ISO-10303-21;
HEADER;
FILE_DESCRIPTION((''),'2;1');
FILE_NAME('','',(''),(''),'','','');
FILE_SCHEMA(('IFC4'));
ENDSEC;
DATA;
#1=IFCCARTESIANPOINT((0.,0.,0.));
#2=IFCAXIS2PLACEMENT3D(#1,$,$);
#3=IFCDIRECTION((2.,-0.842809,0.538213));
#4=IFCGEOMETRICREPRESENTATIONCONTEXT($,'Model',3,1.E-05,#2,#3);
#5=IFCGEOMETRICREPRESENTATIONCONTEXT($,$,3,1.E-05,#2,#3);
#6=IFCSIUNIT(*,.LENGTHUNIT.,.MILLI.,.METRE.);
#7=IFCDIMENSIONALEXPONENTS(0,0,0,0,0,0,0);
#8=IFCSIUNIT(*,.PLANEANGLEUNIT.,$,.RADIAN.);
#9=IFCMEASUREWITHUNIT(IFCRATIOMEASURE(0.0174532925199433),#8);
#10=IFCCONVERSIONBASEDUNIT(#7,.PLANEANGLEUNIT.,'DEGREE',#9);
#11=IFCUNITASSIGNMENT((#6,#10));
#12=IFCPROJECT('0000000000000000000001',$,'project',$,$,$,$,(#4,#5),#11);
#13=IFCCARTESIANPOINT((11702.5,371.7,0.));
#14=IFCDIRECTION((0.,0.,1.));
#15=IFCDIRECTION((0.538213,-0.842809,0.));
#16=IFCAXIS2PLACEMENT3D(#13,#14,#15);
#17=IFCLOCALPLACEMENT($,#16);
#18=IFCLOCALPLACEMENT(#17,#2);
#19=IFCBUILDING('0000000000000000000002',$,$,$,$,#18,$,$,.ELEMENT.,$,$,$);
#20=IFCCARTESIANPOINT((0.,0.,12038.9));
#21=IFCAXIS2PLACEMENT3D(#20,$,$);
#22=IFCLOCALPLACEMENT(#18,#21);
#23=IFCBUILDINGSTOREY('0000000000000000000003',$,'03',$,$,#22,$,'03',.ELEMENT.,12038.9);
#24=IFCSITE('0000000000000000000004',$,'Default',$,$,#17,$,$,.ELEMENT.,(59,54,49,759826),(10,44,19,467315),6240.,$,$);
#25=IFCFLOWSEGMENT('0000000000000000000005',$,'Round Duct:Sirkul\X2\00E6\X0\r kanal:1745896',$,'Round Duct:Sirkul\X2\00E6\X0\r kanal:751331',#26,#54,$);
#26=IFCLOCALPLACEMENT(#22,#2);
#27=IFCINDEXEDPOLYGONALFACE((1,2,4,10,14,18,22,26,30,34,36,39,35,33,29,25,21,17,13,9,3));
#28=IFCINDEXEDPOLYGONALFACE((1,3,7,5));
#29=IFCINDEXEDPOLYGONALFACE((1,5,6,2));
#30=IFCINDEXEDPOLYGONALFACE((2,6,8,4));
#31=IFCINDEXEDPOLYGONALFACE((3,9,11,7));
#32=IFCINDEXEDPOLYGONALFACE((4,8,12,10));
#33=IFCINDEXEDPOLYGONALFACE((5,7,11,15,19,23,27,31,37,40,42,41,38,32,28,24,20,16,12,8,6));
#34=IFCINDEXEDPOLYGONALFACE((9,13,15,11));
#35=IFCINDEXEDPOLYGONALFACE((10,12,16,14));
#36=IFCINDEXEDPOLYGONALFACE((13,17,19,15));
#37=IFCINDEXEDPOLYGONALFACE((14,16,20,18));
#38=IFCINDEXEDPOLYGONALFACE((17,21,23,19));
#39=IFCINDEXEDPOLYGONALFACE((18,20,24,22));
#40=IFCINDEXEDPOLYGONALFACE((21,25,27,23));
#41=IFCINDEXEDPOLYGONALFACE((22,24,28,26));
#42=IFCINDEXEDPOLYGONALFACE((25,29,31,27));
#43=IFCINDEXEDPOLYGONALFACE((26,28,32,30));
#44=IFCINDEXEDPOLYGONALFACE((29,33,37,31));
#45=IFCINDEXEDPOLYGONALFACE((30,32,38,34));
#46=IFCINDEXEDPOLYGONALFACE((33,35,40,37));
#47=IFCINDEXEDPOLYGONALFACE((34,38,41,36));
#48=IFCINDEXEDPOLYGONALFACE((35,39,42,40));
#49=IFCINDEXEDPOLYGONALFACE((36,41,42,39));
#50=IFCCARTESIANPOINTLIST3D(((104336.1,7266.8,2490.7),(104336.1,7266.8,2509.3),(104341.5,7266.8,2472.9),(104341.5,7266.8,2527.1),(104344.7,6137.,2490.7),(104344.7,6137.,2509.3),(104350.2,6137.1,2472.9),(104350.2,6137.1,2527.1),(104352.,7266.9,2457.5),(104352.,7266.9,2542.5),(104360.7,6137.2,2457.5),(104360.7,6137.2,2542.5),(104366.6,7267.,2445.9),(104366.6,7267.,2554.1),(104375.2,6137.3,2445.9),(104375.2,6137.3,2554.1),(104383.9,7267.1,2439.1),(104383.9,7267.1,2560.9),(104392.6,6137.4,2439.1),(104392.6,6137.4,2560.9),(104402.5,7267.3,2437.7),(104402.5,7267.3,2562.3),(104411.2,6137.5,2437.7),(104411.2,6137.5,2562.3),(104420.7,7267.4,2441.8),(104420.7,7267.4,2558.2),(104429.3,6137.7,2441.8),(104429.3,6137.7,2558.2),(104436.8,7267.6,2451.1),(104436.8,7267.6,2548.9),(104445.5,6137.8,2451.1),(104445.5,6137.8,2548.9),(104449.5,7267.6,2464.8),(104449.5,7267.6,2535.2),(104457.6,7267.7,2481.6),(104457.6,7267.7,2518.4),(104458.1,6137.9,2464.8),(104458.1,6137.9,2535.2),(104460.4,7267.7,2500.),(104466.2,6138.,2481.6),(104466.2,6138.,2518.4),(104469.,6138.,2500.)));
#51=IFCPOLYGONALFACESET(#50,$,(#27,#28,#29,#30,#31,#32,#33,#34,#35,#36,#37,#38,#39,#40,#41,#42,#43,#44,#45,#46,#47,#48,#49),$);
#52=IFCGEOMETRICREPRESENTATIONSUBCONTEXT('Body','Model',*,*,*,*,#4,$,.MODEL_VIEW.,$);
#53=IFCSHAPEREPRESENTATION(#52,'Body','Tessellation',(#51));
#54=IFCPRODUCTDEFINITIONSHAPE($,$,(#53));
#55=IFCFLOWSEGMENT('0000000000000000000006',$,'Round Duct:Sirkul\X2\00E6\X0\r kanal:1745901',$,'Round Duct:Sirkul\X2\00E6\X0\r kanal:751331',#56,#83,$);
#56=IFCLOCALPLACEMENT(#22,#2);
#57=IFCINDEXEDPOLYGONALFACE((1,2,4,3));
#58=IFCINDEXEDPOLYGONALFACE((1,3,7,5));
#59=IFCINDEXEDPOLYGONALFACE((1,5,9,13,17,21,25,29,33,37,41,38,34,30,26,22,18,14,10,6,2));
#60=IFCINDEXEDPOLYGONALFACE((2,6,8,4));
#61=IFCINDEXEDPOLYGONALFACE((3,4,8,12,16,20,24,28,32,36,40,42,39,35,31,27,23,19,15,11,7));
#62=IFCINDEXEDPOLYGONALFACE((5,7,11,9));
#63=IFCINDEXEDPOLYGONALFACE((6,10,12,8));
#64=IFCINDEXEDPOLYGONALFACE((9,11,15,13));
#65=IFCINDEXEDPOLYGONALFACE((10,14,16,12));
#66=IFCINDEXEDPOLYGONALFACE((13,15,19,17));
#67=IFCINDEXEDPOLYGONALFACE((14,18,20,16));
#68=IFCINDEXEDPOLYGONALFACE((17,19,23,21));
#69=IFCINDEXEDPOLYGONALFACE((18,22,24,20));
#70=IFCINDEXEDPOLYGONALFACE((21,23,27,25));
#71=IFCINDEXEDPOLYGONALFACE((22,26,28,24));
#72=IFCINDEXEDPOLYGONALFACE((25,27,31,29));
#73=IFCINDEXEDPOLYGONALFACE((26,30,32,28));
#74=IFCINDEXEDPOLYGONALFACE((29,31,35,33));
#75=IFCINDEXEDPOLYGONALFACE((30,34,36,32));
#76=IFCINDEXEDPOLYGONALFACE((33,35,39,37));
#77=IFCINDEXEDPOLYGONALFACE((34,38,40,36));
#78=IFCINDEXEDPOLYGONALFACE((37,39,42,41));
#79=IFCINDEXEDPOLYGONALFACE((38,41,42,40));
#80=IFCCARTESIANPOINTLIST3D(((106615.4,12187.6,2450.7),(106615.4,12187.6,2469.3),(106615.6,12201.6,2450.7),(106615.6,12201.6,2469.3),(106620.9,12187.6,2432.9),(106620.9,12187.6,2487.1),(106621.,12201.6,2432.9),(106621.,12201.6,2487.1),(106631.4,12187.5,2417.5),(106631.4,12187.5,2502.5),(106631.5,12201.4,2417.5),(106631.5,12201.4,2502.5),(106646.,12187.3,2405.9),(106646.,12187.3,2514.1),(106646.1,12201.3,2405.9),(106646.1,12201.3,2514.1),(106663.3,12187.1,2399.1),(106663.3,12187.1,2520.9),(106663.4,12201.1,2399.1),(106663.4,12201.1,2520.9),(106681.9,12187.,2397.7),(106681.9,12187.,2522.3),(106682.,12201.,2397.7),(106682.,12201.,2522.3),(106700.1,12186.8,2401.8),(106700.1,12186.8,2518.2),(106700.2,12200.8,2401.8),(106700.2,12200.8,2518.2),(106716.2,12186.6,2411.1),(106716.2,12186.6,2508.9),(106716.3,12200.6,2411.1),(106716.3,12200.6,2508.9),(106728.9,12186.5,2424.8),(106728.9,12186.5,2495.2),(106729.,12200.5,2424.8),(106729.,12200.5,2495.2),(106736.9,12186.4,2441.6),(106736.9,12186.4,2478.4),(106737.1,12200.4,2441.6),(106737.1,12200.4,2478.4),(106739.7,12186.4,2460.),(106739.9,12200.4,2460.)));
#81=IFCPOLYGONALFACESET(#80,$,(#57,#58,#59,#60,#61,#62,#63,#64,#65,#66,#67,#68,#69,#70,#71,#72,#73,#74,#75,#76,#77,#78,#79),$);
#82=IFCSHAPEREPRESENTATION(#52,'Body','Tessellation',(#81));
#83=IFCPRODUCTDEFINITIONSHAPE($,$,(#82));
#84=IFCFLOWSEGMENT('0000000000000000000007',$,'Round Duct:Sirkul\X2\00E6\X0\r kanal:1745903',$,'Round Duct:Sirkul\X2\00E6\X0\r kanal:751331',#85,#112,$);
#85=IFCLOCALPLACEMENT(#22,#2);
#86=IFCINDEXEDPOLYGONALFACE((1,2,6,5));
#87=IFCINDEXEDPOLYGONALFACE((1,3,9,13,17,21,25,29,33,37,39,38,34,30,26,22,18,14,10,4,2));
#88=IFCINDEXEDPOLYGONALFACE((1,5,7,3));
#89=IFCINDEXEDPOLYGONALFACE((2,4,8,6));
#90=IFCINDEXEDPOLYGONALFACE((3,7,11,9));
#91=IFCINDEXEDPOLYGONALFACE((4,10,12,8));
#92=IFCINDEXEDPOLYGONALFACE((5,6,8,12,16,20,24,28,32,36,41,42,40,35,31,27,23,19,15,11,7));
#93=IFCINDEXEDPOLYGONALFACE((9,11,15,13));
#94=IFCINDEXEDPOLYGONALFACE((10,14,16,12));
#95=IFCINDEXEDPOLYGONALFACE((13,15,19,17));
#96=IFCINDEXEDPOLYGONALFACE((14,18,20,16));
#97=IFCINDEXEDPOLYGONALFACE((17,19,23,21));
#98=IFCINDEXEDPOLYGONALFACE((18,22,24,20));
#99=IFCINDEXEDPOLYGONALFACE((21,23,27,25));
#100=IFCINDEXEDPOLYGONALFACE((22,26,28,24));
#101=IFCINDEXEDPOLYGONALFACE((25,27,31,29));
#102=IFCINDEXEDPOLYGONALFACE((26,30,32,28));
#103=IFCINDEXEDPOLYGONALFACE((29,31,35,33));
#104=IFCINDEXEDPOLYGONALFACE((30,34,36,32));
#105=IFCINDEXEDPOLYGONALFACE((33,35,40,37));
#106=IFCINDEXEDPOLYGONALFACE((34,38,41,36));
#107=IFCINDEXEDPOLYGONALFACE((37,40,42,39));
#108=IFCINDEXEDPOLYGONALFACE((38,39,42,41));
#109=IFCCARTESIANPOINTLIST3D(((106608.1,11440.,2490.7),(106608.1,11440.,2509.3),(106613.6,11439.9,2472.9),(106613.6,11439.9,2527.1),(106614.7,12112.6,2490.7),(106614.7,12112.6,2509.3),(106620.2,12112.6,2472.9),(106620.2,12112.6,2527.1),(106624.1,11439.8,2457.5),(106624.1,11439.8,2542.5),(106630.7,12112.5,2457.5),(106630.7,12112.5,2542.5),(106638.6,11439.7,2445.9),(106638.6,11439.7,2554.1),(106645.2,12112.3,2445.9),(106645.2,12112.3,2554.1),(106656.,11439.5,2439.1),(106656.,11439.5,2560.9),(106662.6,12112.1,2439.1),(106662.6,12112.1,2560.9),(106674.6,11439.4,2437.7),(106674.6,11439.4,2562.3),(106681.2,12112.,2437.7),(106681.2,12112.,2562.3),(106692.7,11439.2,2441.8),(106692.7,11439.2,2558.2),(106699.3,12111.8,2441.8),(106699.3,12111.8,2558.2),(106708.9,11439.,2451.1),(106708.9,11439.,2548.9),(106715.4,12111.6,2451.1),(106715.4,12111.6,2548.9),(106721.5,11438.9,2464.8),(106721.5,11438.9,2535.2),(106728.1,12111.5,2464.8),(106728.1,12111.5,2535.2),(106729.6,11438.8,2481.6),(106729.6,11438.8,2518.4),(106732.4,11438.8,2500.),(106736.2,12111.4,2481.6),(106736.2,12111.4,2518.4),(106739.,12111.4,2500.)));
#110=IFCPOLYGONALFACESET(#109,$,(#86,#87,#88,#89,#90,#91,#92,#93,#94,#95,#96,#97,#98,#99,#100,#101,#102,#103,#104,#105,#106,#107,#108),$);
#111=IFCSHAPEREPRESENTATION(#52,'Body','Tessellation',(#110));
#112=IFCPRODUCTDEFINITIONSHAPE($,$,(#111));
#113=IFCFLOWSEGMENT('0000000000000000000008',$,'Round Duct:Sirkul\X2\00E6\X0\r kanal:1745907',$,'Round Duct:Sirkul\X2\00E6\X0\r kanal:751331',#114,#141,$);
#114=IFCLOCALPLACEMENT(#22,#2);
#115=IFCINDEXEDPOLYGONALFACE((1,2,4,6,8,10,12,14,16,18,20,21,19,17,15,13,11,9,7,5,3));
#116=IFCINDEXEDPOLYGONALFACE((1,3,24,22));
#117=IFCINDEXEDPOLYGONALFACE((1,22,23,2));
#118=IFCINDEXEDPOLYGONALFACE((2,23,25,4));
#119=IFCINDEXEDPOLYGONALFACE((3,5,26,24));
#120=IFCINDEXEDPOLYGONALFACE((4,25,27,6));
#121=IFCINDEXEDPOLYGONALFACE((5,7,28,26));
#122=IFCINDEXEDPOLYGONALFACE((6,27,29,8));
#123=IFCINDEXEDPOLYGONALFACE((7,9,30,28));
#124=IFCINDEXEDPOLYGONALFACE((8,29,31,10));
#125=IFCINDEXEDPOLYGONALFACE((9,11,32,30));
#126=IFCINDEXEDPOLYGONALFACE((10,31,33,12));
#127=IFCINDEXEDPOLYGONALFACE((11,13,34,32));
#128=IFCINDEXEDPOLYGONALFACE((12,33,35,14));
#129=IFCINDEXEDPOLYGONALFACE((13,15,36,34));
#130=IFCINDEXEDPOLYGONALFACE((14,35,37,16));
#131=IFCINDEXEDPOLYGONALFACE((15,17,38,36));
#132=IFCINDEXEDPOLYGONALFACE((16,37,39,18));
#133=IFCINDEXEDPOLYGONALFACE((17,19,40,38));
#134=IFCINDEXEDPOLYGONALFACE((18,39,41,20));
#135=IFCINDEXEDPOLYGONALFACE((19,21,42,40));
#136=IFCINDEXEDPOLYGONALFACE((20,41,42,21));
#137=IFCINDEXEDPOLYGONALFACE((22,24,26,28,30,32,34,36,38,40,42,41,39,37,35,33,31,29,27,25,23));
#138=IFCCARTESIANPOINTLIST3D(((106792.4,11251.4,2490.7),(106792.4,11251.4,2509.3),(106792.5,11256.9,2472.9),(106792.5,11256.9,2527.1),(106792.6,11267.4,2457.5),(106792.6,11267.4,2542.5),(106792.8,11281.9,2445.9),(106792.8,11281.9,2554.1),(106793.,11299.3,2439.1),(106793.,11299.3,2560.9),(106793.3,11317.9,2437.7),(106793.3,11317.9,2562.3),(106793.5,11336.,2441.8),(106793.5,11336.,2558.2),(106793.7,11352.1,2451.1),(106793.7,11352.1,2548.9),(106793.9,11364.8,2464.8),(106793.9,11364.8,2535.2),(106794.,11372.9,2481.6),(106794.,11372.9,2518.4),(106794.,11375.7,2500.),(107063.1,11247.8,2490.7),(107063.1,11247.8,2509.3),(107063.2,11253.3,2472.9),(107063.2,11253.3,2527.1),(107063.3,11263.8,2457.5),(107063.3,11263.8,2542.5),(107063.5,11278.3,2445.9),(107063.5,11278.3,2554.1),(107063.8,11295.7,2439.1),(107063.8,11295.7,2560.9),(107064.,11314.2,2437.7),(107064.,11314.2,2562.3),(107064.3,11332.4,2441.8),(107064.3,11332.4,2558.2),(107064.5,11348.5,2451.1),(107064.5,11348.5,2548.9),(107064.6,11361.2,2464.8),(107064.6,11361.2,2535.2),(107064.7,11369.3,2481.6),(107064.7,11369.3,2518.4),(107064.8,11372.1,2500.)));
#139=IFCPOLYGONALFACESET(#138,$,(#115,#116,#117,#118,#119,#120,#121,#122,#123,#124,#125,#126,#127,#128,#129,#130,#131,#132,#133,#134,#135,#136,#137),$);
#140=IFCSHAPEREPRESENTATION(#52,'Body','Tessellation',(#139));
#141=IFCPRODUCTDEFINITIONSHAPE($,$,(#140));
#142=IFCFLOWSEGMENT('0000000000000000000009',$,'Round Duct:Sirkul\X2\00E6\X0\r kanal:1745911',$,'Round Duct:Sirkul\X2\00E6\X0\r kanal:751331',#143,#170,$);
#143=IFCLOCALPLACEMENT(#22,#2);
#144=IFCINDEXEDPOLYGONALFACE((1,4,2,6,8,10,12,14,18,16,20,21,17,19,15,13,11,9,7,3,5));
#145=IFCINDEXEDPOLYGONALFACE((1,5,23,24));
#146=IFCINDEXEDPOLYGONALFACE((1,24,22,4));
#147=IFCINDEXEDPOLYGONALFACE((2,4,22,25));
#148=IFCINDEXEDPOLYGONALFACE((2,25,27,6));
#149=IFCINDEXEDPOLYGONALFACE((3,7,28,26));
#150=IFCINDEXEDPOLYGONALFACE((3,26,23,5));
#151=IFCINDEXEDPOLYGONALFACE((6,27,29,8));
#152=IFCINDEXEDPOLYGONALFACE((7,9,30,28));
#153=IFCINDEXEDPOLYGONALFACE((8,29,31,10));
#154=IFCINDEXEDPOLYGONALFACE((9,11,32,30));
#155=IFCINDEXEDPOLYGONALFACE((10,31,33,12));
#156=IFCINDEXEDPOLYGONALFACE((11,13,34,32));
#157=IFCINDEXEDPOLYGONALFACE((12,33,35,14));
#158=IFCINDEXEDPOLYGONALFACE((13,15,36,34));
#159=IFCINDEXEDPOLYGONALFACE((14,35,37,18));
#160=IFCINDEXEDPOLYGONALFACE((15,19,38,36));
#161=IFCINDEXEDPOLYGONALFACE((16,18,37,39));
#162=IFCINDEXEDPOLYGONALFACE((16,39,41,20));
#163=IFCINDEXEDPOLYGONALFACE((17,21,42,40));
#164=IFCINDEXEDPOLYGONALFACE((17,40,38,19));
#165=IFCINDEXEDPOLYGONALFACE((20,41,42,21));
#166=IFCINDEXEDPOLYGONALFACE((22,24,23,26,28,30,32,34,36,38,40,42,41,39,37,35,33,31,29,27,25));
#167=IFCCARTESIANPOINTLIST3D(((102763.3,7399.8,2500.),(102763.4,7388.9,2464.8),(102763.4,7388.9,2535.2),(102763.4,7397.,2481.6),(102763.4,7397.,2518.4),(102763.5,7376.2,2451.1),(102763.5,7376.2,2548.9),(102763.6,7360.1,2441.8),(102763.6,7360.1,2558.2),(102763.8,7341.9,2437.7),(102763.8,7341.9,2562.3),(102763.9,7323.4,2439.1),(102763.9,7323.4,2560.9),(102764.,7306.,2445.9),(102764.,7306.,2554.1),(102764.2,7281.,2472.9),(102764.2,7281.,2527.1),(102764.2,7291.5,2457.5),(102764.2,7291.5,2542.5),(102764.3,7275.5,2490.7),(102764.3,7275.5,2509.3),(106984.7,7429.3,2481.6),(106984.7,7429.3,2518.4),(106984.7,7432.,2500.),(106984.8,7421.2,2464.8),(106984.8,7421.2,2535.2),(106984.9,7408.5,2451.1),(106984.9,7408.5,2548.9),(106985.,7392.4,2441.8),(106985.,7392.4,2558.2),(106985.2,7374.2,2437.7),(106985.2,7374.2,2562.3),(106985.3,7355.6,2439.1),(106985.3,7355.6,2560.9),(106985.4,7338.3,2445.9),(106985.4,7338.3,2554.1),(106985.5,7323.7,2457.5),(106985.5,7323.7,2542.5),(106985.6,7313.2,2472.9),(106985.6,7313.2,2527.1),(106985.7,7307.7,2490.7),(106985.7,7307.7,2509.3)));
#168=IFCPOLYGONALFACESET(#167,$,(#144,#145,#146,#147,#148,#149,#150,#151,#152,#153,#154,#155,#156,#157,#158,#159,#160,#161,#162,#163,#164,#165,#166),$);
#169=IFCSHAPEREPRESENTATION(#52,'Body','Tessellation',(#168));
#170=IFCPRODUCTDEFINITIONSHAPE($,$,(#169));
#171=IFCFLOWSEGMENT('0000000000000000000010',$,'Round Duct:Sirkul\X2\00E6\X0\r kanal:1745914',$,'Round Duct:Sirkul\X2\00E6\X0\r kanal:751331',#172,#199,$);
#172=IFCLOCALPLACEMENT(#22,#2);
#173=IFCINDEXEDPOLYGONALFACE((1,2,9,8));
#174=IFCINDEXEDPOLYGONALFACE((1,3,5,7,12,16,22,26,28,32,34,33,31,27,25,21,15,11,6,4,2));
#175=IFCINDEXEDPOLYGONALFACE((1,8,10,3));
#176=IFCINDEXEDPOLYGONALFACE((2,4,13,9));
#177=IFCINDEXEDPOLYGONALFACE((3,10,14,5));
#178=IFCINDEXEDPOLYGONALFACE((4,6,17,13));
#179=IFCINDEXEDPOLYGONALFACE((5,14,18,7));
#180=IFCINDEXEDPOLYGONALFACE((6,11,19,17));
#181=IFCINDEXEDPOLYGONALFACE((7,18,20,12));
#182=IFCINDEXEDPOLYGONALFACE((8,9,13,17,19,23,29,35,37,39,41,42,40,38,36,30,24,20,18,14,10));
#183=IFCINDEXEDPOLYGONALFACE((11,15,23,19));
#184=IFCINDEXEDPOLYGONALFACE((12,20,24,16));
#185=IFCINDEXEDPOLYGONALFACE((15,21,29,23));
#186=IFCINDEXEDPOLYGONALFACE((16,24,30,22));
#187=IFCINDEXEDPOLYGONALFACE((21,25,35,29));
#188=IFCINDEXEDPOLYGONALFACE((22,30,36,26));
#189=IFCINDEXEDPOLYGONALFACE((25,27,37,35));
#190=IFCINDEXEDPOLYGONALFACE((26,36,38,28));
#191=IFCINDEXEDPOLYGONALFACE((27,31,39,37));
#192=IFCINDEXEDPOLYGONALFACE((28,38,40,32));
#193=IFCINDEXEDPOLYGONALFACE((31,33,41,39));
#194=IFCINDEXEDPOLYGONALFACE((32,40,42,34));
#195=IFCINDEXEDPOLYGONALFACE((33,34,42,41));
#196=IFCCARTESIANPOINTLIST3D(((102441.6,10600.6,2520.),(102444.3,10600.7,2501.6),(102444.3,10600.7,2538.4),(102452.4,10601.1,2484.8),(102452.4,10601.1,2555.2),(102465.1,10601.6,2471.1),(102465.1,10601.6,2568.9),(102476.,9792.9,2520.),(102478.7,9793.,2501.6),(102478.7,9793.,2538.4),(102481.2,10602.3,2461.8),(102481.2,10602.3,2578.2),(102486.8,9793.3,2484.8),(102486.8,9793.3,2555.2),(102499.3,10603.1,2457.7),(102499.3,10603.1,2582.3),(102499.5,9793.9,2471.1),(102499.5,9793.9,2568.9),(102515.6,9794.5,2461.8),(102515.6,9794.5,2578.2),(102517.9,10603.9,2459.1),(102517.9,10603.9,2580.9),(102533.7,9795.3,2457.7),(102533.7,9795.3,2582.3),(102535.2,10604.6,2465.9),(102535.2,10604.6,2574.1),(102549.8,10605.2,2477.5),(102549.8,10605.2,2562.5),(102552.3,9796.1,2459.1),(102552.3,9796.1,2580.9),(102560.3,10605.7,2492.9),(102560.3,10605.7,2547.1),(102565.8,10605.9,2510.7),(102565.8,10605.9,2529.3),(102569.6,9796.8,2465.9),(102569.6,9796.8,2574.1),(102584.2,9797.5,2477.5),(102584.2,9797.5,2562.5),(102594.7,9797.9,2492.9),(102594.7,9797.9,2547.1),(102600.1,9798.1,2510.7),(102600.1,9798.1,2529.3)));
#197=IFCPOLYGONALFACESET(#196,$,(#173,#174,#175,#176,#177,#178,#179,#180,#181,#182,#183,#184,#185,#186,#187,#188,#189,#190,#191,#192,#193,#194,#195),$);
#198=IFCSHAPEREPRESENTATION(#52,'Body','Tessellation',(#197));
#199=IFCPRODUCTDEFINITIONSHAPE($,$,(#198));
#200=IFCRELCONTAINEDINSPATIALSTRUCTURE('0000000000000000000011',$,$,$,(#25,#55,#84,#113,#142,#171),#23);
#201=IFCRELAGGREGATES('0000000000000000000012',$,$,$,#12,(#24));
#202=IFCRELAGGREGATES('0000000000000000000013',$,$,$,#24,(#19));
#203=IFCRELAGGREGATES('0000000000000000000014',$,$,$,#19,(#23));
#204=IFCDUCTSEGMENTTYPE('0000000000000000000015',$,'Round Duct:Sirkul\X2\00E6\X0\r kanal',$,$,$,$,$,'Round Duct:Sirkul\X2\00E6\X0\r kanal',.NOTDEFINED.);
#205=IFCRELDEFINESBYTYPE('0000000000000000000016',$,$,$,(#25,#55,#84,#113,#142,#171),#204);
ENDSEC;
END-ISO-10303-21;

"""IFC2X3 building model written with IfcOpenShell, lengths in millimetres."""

from ifc_helpers import new_model, entity, si_unit, converted_unit, direction, frame, frame_2d, origin, origin_2d_with_axis, place, context, subcontext, project, spatial, circle, extrude, type_object, element, save


model = new_model("IFC2X3")

# Units and contexts
model_context = context("Model", 3, precision=1e-05, world=origin(), true_north=direction((2.0, -0.842809, 0.538213)))
context_of_model = context(None, 3, precision=1e-05, world=origin(), true_north=direction((2.0, -0.842809, 0.538213)))
body_context = subcontext(model_context, "Body", "Model", "MODEL_VIEW")
ifc_project = project(units=[si_unit("LENGTHUNIT", "METRE", prefix="MILLI"), converted_unit("PLANEANGLEUNIT", "DEGREE", entity("IfcRatioMeasure", 0.0174532925199433), si_unit("PLANEANGLEUNIT", "RADIAN"), dimensions=[0, 0, 0, 0, 0, 0, 0])], contexts=[model_context, context_of_model])

# Site, building, storey
site_placement = place(None, frame((11702.5, 371.7, 0.0), z_axis=(0.0, 0.0, 1.0), x_axis=(0.538213, -0.842809, 0.0)))
site = spatial("IfcSite", under=ifc_project, at=site_placement, Name="Default", CompositionType="ELEMENT", RefLatitude=(59, 54, 49, 759826), RefLongitude=(10, 44, 19, 467315), RefElevation=6240.0)
building_placement = place(site_placement, origin())
building = spatial("IfcBuilding", under=site, at=building_placement, CompositionType="ELEMENT")
storey_placement = place(building_placement, frame((0.0, 0.0, 12038.9)))
storey = spatial("IfcBuildingStorey", under=building, at=storey_placement, Name="03", LongName="03", CompositionType="ELEMENT", Elevation=12038.9)

# Flow segments
duct_segment_type = type_object("IfcDuctSegmentType", Name="Round Duct:Sirkulær kanal", ElementType="Round Duct:Sirkulær kanal", PredefinedType="NOTDEFINED")
flow_segment_1_placement = place(storey_placement, origin())
element("IfcFlowSegment", 1, at=flow_segment_1_placement, inside=storey, type_object=duct_segment_type, Name="Round Duct:Sirkulær kanal:1745896", ObjectType="Round Duct:Sirkulær kanal:751331", context=body_context, shape_type="SweptSolid", body=[
    extrude(circle(Radius=62.5, at=origin_2d_with_axis()), frame((104406.5, 6137.5, 2500.0), z_axis=(-0.007643, 0.999971, 0.0), x_axis=(0.999971, 0.007643, 0.0)), (0.0, 0.0, 1.0), 1129.8),
])
flow_segment_2_placement = place(storey_placement, origin())
element("IfcFlowSegment", 2, at=flow_segment_2_placement, inside=storey, type_object=duct_segment_type, Name="Round Duct:Sirkulær kanal:1745901", ObjectType="Round Duct:Sirkulær kanal:751331", context=body_context, shape_type="SweptSolid", body=[
    extrude(circle(Radius=62.5, at=frame_2d((0.0, 0.0), x_axis=(1.0, 0.0))), frame((106677.2, 12187.0, 2460.0), z_axis=(0.00981, 0.999952, 0.0), x_axis=(0.999952, -0.00981, 0.0)), (0.0, 0.0, 1.0), 14.0),
])
flow_segment_3_placement = place(storey_placement, origin())
element("IfcFlowSegment", 3, at=flow_segment_3_placement, inside=storey, type_object=duct_segment_type, Name="Round Duct:Sirkulær kanal:1745903", ObjectType="Round Duct:Sirkulær kanal:751331", context=body_context, shape_type="SweptSolid", body=[
    extrude(circle(Radius=62.5, at=origin_2d_with_axis()), frame((106669.9, 11439.4, 2500.0), z_axis=(0.00981, 0.999952, 0.0), x_axis=(0.999952, -0.00981, 0.0)), (0.0, 0.0, 1.0), 672.6),
])
flow_segment_4_placement = place(storey_placement, origin())
element("IfcFlowSegment", 4, at=flow_segment_4_placement, inside=storey, type_object=duct_segment_type, Name="Round Duct:Sirkulær kanal:1745907", ObjectType="Round Duct:Sirkulær kanal:751331", context=body_context, shape_type="SweptSolid", body=[
    extrude(circle(Radius=62.5, at=origin_2d_with_axis()), frame((107064.0, 11309.6, 2500.0), z_axis=(-0.999911, 0.013345, 0.0), x_axis=(0.013345, 0.999911, 0.0)), (0.0, 0.0, 1.0), 270.8),
])
flow_segment_5_placement = place(storey_placement, origin())
element("IfcFlowSegment", 5, at=flow_segment_5_placement, inside=storey, type_object=duct_segment_type, Name="Round Duct:Sirkulær kanal:1745911", ObjectType="Round Duct:Sirkulær kanal:751331", context=body_context, shape_type="SweptSolid", body=[
    extrude(circle(Radius=62.5, at=origin_2d_with_axis()), frame((102763.8, 7337.3, 2500.0), z_axis=(0.999971, 0.007643, 0.0), x_axis=(-0.007643, 0.999971, 0.0)), (0.0, 0.0, 1.0), 4221.5),
])
flow_segment_6_placement = place(storey_placement, origin())
element("IfcFlowSegment", 6, at=flow_segment_6_placement, inside=storey, type_object=duct_segment_type, Name="Round Duct:Sirkulær kanal:1745914", ObjectType="Round Duct:Sirkulær kanal:751331", context=body_context, shape_type="SweptSolid", body=[
    extrude(circle(Radius=62.5, at=frame_2d((0.0, 0.0), x_axis=(1.0, 0.0))), frame((102504.0, 10603.3, 2520.0), z_axis=(0.042537, -0.999095, 0.0), x_axis=(-0.999095, -0.042537, 0.0)), (0.0, 0.0, 1.0), 808.5),
])

save(model, "model.ifc")
